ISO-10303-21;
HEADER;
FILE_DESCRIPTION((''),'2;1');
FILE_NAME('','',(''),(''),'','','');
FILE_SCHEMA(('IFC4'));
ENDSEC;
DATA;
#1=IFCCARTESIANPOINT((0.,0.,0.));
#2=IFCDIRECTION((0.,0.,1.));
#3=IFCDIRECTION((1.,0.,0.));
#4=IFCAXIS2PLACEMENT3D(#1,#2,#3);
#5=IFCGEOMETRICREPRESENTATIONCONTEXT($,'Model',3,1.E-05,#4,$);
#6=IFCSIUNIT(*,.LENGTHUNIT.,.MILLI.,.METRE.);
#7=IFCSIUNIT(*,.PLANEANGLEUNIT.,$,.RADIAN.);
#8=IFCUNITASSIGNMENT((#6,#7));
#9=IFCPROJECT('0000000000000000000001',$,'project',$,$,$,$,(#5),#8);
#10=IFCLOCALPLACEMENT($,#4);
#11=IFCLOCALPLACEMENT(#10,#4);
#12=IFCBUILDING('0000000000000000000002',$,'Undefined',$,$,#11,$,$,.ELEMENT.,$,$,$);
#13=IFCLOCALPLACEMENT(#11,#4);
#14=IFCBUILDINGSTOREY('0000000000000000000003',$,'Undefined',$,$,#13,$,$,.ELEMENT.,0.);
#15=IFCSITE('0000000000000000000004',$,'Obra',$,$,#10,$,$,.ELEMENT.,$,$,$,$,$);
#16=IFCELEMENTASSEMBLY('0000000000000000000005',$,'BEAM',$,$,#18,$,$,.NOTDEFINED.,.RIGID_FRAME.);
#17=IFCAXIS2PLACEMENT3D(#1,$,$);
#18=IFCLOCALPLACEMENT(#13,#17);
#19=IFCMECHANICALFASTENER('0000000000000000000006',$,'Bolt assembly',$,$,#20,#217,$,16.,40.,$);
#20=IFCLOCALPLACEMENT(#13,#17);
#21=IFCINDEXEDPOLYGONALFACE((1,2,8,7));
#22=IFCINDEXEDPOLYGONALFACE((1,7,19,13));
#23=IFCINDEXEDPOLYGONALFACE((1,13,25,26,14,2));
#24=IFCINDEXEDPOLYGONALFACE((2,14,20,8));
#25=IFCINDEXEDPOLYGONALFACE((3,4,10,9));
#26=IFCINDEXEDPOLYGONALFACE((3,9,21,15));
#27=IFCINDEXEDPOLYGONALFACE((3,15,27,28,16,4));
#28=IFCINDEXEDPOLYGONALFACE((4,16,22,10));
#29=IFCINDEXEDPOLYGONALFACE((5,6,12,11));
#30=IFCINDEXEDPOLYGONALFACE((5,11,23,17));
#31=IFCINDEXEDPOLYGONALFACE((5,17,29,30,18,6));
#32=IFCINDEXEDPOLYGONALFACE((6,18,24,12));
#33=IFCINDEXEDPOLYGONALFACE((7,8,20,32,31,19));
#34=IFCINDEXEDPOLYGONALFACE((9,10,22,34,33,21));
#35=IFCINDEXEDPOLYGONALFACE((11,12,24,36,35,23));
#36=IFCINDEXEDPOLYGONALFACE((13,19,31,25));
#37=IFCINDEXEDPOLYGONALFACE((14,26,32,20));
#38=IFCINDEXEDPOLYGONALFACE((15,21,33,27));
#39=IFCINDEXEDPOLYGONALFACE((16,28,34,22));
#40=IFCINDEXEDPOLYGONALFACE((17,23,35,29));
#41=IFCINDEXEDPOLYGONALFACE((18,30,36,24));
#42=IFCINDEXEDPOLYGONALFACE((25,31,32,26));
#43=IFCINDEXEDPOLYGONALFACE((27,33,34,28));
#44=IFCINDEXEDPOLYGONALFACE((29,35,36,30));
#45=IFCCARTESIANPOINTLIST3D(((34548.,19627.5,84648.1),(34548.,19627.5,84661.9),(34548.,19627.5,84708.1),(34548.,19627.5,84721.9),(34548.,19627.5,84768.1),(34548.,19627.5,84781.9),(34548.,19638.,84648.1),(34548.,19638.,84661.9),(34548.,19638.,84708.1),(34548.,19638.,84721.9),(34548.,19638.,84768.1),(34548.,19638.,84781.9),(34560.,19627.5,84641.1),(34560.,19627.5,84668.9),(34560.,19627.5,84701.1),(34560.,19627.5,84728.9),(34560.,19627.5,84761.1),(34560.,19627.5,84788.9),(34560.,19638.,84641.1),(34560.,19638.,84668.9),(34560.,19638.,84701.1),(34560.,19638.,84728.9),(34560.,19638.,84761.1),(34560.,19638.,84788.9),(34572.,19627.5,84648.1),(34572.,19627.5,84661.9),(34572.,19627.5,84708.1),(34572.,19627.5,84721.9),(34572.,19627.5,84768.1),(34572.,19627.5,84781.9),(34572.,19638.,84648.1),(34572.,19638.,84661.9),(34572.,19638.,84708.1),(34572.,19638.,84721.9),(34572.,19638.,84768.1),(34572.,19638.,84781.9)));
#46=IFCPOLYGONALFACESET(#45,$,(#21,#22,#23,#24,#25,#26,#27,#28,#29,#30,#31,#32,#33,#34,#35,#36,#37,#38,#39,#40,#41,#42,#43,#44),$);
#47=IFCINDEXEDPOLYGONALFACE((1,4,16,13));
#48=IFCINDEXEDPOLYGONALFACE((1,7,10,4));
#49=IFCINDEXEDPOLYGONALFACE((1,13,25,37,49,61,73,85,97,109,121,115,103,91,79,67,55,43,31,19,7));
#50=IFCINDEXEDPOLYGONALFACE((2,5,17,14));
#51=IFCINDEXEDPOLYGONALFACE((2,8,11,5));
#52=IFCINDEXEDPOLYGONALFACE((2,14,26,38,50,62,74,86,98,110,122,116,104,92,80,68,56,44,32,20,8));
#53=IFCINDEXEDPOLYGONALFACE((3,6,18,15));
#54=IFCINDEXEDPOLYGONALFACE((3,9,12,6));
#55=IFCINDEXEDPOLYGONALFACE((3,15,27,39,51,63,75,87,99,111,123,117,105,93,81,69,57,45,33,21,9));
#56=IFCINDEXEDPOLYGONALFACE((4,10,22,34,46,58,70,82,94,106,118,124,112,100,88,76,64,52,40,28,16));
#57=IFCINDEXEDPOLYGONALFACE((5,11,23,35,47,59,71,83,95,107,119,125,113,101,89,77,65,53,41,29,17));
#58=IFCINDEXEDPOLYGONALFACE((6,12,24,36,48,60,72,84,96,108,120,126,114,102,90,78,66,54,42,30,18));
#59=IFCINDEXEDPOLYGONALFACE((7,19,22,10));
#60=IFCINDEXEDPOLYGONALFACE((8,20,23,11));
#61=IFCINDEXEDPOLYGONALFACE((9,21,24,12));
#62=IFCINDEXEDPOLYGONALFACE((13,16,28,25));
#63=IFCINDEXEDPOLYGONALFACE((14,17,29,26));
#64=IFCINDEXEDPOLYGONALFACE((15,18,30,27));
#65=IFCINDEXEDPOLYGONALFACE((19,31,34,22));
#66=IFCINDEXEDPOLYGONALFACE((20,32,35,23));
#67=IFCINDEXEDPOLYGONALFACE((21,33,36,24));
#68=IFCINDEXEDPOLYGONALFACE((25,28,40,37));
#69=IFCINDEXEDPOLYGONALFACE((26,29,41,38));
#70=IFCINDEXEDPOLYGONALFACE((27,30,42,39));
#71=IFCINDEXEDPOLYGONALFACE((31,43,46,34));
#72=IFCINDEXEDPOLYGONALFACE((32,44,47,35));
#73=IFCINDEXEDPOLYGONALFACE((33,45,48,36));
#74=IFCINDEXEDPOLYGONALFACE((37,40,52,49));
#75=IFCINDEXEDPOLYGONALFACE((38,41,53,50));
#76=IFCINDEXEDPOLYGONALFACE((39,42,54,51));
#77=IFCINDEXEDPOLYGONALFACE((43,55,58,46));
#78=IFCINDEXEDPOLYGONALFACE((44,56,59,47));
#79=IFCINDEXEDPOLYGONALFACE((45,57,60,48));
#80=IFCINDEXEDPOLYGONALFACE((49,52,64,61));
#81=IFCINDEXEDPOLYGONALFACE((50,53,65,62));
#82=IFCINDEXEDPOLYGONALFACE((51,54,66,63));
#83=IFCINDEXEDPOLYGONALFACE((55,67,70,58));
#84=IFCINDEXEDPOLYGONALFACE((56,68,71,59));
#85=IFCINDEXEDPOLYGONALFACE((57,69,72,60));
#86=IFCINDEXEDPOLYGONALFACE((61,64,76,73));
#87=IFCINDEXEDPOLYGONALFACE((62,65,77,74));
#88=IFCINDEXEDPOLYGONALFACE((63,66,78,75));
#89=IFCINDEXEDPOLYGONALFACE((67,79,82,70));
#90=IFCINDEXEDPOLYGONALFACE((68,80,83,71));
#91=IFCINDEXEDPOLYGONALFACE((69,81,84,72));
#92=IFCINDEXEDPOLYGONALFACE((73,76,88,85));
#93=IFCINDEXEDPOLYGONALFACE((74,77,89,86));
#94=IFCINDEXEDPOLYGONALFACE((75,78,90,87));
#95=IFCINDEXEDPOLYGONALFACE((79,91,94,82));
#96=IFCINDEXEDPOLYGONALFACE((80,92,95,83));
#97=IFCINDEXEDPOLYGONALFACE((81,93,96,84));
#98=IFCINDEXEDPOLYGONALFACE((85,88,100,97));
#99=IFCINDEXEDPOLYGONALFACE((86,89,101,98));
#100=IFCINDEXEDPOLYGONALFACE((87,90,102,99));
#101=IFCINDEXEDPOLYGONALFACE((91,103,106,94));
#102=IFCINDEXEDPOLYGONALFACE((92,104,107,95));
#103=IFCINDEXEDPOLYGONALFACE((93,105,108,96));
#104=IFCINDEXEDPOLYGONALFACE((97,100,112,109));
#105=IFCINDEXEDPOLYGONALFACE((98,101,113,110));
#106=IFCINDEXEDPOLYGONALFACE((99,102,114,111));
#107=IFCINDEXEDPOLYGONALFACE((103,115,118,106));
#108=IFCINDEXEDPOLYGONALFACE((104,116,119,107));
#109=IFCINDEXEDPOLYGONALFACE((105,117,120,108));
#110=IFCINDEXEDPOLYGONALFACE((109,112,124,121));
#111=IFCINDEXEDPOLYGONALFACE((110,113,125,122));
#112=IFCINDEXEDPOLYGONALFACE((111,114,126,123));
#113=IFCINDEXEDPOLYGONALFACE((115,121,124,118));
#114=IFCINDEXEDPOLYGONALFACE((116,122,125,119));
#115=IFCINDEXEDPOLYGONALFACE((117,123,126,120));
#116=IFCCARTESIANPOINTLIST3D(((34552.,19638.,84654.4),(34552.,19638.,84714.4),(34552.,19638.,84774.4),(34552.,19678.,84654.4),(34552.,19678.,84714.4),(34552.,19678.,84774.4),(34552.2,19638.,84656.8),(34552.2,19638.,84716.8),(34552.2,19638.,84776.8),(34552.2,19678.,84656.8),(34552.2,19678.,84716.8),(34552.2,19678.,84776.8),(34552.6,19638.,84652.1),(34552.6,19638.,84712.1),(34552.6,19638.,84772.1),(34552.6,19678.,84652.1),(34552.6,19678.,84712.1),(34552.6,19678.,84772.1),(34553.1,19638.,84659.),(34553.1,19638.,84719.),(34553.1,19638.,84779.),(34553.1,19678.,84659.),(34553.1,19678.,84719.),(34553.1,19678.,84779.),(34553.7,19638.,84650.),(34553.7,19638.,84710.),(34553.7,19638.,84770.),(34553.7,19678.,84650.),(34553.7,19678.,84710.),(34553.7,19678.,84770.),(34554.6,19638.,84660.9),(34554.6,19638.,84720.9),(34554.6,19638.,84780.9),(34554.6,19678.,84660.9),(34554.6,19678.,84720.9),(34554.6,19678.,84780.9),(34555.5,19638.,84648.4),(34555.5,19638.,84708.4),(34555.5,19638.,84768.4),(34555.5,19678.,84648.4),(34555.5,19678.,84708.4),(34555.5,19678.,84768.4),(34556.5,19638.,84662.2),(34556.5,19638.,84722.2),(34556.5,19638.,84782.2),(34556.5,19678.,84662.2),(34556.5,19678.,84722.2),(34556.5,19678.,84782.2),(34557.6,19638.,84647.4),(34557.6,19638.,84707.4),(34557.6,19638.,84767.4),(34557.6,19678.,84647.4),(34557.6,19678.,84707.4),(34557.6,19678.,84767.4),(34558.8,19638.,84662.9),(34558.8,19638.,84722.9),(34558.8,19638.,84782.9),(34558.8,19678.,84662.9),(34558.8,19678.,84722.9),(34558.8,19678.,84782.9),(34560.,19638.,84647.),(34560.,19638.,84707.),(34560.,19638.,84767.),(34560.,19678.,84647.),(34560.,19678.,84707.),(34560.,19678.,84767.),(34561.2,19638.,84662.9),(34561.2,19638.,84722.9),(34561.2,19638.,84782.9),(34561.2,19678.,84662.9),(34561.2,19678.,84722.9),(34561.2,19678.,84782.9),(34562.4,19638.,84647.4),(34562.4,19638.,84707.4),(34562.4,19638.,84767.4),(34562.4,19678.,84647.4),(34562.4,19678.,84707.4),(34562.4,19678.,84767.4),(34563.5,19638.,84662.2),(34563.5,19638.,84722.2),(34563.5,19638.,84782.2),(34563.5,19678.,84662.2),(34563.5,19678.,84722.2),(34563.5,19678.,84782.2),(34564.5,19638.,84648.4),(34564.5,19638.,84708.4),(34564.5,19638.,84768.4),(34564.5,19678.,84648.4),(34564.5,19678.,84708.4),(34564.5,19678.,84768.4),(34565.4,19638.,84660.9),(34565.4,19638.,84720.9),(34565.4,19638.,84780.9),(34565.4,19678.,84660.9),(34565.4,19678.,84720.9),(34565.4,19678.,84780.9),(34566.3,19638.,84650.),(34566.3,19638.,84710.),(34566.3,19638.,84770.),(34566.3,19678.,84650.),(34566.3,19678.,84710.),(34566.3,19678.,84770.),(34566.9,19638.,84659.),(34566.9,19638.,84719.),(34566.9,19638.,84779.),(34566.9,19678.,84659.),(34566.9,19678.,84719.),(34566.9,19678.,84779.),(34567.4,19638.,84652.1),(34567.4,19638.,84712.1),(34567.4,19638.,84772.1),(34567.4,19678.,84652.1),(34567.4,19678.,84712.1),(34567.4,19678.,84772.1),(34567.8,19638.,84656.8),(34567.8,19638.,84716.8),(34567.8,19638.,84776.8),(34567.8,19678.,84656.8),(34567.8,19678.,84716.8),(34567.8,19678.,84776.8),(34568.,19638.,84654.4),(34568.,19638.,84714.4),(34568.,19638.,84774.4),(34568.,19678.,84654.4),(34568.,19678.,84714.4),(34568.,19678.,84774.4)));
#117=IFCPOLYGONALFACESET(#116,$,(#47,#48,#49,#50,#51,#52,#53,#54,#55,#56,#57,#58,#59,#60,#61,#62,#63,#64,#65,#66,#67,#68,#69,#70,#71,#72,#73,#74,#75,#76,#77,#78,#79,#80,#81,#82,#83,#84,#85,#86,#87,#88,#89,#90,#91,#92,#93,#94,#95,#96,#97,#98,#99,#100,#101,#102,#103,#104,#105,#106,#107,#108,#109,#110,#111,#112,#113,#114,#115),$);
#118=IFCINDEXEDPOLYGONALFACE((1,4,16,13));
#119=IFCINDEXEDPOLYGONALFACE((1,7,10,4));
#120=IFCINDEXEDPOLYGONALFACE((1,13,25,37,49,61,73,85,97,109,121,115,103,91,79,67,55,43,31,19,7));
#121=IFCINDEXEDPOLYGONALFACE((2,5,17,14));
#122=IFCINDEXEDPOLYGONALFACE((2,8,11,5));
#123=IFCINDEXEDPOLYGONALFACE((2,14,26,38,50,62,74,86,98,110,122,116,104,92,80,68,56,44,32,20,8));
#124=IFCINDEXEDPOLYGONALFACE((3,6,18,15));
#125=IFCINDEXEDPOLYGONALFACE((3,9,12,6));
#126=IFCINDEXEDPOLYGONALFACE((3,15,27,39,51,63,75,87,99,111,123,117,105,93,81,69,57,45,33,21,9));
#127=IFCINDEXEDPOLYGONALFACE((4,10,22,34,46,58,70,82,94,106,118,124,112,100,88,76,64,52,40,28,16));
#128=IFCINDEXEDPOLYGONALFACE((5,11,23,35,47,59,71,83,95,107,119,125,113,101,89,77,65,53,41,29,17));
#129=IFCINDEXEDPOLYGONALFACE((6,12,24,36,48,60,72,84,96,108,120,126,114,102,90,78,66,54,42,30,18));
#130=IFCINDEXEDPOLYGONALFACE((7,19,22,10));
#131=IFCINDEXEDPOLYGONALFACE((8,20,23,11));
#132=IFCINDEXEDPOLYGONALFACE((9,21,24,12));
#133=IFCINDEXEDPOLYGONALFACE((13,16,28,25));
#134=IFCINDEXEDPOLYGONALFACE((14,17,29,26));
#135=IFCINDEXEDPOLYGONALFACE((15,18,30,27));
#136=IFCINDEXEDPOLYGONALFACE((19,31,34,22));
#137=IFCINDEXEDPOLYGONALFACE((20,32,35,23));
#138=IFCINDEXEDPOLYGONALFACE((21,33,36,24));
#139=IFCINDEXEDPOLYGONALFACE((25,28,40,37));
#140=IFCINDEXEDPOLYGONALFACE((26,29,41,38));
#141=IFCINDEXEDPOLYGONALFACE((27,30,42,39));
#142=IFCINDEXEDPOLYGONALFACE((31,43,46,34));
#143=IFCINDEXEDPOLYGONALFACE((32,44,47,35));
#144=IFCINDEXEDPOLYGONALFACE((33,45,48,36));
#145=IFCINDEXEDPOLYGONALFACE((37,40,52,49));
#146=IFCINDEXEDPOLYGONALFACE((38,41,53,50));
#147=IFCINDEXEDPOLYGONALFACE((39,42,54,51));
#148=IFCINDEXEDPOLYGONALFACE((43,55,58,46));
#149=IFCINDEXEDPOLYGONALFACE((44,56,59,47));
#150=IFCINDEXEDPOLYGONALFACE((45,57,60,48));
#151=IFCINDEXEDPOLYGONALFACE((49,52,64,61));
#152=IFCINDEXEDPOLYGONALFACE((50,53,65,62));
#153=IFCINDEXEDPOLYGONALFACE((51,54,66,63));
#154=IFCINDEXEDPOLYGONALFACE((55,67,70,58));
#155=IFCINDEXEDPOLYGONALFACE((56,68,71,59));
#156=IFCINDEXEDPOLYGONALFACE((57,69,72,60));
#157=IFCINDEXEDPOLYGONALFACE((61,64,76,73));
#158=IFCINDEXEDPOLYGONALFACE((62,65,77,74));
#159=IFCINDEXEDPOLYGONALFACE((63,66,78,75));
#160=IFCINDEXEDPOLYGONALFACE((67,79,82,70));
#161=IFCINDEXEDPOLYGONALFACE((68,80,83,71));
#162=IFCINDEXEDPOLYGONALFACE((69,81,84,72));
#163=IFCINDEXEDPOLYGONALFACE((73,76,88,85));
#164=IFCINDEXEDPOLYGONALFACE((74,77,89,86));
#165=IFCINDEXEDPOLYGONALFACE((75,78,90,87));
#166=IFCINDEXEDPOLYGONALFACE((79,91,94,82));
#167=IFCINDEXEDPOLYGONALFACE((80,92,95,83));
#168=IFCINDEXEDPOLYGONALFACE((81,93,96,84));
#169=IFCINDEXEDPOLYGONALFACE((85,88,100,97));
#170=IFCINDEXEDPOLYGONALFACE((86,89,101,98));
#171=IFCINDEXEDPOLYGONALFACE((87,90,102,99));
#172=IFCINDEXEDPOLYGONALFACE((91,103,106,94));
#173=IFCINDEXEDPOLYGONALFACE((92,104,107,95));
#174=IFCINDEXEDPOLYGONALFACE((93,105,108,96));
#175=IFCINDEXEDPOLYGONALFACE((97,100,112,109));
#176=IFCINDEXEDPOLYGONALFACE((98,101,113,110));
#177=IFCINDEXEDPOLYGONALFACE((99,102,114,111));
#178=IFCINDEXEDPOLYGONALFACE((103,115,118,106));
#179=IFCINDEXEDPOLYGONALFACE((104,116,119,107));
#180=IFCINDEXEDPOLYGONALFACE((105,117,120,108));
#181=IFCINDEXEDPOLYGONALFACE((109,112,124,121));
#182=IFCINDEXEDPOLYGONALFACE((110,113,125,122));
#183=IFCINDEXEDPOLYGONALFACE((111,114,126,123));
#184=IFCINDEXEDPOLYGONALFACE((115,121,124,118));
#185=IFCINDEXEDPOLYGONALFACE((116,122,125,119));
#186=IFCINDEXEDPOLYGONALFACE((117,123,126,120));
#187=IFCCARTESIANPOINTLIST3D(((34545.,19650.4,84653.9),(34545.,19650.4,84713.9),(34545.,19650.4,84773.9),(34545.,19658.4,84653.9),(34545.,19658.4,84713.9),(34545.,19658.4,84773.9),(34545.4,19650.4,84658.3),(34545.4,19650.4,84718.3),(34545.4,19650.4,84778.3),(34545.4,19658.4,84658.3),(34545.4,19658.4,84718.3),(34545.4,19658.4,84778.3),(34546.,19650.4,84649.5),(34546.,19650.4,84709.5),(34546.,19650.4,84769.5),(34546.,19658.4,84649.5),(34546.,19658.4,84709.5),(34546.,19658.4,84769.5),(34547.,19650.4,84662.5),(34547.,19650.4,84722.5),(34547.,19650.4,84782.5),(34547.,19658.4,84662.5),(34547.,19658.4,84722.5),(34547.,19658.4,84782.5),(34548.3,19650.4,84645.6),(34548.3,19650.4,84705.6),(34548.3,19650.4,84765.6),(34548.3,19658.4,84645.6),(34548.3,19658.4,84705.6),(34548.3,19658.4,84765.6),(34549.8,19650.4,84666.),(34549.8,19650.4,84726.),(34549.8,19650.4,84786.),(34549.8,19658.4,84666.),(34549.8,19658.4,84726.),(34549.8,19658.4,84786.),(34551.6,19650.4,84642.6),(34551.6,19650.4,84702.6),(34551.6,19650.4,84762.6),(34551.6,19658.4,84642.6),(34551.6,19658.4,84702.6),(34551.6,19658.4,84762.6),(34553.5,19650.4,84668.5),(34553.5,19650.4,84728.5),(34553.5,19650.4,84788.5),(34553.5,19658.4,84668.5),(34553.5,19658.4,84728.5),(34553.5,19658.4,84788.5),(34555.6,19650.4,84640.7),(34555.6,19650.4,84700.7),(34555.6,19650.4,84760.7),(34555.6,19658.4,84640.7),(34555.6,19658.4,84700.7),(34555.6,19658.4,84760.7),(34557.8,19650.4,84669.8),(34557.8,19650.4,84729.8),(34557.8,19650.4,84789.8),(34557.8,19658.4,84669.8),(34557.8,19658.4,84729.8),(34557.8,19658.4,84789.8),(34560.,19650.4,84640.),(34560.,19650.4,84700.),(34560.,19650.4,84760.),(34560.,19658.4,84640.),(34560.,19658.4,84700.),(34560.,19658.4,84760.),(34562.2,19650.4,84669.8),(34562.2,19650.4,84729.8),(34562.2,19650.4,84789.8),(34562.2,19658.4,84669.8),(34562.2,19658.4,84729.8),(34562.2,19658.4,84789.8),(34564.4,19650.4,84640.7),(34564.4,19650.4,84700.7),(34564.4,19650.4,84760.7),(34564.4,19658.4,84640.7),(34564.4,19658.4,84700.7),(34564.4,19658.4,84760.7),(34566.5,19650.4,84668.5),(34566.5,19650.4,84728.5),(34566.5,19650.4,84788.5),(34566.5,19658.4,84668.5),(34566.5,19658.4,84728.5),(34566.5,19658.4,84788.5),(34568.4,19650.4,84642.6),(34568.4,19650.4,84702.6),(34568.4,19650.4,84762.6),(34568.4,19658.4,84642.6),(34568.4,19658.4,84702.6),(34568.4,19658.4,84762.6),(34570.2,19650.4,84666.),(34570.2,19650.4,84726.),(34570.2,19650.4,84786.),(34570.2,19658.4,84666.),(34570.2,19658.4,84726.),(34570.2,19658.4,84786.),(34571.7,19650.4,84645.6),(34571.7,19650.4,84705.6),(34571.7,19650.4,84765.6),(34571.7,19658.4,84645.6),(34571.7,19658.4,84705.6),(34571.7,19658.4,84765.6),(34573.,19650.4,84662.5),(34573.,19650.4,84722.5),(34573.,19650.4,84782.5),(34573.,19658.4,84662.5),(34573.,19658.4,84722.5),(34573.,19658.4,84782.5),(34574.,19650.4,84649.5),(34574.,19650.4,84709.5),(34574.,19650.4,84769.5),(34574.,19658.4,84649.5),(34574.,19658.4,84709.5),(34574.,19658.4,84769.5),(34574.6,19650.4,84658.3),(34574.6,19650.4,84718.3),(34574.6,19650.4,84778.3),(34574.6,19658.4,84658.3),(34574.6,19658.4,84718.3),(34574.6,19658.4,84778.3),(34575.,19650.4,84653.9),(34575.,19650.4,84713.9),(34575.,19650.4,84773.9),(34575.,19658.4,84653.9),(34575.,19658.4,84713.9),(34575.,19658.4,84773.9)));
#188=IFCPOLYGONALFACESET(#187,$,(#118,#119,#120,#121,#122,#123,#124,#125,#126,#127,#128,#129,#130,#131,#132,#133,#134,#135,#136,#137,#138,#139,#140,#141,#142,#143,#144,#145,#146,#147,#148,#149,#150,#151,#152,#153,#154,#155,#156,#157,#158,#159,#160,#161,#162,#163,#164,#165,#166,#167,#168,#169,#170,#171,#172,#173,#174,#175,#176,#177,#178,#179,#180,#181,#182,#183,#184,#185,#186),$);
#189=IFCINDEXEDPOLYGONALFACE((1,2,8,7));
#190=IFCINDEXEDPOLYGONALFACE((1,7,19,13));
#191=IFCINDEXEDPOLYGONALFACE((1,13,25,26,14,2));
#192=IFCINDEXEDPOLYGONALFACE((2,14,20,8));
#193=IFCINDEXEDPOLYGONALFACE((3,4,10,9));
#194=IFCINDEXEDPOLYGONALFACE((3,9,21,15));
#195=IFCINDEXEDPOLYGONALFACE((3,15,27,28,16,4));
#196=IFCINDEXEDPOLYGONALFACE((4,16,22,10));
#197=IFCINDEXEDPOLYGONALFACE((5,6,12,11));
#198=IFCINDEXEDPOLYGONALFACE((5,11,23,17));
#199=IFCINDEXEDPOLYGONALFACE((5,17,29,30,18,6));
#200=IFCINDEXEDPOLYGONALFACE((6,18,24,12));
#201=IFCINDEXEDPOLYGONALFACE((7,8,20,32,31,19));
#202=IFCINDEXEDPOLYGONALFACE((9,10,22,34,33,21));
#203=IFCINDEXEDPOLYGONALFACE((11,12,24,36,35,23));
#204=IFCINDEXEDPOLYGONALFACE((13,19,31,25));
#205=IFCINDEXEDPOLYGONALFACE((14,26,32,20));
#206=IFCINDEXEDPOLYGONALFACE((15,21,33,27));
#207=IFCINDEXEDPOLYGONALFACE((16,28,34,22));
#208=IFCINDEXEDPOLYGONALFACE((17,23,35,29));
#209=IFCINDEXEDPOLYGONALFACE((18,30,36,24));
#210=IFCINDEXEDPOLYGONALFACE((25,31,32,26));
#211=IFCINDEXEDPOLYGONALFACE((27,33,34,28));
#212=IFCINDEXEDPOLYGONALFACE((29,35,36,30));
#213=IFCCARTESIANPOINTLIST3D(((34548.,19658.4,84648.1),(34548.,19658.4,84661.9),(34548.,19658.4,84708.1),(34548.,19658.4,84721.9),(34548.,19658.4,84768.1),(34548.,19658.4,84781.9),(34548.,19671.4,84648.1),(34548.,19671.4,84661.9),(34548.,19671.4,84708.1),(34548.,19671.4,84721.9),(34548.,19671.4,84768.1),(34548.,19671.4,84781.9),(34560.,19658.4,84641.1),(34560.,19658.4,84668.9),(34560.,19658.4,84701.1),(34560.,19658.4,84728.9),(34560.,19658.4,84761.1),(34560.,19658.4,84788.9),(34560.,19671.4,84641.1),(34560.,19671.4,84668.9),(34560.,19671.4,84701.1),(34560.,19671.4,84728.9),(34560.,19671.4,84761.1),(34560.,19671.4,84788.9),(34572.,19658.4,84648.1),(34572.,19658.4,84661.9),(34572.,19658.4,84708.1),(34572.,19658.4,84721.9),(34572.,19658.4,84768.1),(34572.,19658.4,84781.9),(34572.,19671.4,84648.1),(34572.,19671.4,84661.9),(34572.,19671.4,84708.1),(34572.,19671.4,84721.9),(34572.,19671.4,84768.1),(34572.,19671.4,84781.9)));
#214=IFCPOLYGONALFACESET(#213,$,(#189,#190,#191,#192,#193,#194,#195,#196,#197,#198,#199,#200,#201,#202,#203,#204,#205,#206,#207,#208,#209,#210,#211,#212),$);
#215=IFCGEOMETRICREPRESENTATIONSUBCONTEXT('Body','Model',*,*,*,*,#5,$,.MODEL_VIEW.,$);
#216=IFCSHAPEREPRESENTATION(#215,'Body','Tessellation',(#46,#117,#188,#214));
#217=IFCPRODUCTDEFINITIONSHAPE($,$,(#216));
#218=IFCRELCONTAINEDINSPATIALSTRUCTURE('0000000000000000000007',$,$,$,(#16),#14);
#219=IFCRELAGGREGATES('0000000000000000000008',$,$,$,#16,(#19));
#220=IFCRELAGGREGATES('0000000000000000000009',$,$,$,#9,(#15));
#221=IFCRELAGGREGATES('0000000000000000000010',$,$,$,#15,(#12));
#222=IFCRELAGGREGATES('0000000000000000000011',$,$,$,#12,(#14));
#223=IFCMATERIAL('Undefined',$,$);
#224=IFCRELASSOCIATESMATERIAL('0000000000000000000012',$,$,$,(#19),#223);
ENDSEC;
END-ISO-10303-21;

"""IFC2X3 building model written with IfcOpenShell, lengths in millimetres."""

from ifc_helpers import new_model, si_unit, frame, origin_with_axes, origin_2d_with_axis, place, context, subcontext, project, spatial, polyline, circle, outline, extrude, source, transform, mapped, material, element, aggregate, save


model = new_model("IFC2X3")

# Units and contexts
model_context = context("Model", 3, precision=1e-05, world=origin_with_axes())
body_context = subcontext(model_context, "Body", "Model", "MODEL_VIEW")
ifc_project = project(units=[si_unit("LENGTHUNIT", "METRE", prefix="MILLI"), si_unit("PLANEANGLEUNIT", "RADIAN")], contexts=[model_context])

# Site, building, storey
site_placement = place(None, origin_with_axes())
site = spatial("IfcSite", under=ifc_project, at=site_placement, Name="Obra", CompositionType="ELEMENT")
building_placement = place(site_placement, origin_with_axes())
building = spatial("IfcBuilding", under=site, at=building_placement, Name="Undefined", CompositionType="ELEMENT")
storey_placement = place(building_placement, origin_with_axes())
storey = spatial("IfcBuildingStorey", under=building, at=storey_placement, Name="Undefined", CompositionType="ELEMENT", Elevation=0.0)

# Element assembly, mechanical fastener
assembly_1_placement = place(storey_placement, origin_with_axes())
assembly_1 = element("IfcElementAssembly", 1, at=assembly_1_placement, inside=storey, Name="BEAM", AssemblyPlace="NOTDEFINED", PredefinedType="RIGID_FRAME")
ifc_material_1 = material(Name="Undefined")
shared_shape_1 = source(origin_with_axes(), body_context, "Body", "SweptSolid", [
    extrude(outline(polyline([(13.9, 0.0), (6.9, 12.0), (-6.9, 12.0), (-13.9, 0.0), (-6.9, -12.0), (6.9, -12.0), (13.9, 0.0)])), frame((0.0, -19.7, 0.0), z_axis=(0.0, 1.0, 0.0), x_axis=(1.0, 0.0, 0.0)), (0.0, 0.0, 1.0), 10.6),
    extrude(circle(Radius=8.0, at=origin_2d_with_axis()), frame((0.0, -9.1, 0.0), z_axis=(0.0, 1.0, 0.0), x_axis=(1.0, 0.0, 0.0)), (0.0, 0.0, 1.0), 40.0),
    extrude(circle(Radius=15.0, at=origin_2d_with_axis()), frame((0.0, 3.3, 0.0), z_axis=(0.0, 1.0, 0.0), x_axis=(1.0, 0.0, 0.0)), (0.0, 0.0, 1.0), 8.0),
    extrude(outline(polyline([(13.9, 0.0), (6.9, 12.0), (-6.9, 12.0), (-13.9, 0.0), (-6.9, -12.0), (6.9, -12.0), (13.9, 0.0)])), frame((0.0, 11.3, 0.0), z_axis=(0.0, 1.0, 0.0), x_axis=(1.0, 0.0, 0.0)), (0.0, 0.0, 1.0), 13.0),
])
mechanical_fastener_1_placement = place(assembly_1_placement, frame((34510.0, 19647.1, 84835.0), z_axis=(1.0, 0.0, 0.0), x_axis=(0.0, 0.0, -1.0)))
mechanical_fastener_1 = element("IfcMechanicalFastener", 2, at=mechanical_fastener_1_placement, material=ifc_material_1, Name="Bolt assembly", NominalDiameter=16.0, NominalLength=40.0, context=body_context, shape_type="MappedRepresentation", body=[
    mapped(shared_shape_1, transform((60.0, 0.0, 50.0))),
    mapped(shared_shape_1, transform((120.0, 0.0, 50.0))),
    mapped(shared_shape_1, transform((180.0, 0.0, 50.0))),
])
aggregate(assembly_1, [mechanical_fastener_1])

save(model, "model.ifc")
